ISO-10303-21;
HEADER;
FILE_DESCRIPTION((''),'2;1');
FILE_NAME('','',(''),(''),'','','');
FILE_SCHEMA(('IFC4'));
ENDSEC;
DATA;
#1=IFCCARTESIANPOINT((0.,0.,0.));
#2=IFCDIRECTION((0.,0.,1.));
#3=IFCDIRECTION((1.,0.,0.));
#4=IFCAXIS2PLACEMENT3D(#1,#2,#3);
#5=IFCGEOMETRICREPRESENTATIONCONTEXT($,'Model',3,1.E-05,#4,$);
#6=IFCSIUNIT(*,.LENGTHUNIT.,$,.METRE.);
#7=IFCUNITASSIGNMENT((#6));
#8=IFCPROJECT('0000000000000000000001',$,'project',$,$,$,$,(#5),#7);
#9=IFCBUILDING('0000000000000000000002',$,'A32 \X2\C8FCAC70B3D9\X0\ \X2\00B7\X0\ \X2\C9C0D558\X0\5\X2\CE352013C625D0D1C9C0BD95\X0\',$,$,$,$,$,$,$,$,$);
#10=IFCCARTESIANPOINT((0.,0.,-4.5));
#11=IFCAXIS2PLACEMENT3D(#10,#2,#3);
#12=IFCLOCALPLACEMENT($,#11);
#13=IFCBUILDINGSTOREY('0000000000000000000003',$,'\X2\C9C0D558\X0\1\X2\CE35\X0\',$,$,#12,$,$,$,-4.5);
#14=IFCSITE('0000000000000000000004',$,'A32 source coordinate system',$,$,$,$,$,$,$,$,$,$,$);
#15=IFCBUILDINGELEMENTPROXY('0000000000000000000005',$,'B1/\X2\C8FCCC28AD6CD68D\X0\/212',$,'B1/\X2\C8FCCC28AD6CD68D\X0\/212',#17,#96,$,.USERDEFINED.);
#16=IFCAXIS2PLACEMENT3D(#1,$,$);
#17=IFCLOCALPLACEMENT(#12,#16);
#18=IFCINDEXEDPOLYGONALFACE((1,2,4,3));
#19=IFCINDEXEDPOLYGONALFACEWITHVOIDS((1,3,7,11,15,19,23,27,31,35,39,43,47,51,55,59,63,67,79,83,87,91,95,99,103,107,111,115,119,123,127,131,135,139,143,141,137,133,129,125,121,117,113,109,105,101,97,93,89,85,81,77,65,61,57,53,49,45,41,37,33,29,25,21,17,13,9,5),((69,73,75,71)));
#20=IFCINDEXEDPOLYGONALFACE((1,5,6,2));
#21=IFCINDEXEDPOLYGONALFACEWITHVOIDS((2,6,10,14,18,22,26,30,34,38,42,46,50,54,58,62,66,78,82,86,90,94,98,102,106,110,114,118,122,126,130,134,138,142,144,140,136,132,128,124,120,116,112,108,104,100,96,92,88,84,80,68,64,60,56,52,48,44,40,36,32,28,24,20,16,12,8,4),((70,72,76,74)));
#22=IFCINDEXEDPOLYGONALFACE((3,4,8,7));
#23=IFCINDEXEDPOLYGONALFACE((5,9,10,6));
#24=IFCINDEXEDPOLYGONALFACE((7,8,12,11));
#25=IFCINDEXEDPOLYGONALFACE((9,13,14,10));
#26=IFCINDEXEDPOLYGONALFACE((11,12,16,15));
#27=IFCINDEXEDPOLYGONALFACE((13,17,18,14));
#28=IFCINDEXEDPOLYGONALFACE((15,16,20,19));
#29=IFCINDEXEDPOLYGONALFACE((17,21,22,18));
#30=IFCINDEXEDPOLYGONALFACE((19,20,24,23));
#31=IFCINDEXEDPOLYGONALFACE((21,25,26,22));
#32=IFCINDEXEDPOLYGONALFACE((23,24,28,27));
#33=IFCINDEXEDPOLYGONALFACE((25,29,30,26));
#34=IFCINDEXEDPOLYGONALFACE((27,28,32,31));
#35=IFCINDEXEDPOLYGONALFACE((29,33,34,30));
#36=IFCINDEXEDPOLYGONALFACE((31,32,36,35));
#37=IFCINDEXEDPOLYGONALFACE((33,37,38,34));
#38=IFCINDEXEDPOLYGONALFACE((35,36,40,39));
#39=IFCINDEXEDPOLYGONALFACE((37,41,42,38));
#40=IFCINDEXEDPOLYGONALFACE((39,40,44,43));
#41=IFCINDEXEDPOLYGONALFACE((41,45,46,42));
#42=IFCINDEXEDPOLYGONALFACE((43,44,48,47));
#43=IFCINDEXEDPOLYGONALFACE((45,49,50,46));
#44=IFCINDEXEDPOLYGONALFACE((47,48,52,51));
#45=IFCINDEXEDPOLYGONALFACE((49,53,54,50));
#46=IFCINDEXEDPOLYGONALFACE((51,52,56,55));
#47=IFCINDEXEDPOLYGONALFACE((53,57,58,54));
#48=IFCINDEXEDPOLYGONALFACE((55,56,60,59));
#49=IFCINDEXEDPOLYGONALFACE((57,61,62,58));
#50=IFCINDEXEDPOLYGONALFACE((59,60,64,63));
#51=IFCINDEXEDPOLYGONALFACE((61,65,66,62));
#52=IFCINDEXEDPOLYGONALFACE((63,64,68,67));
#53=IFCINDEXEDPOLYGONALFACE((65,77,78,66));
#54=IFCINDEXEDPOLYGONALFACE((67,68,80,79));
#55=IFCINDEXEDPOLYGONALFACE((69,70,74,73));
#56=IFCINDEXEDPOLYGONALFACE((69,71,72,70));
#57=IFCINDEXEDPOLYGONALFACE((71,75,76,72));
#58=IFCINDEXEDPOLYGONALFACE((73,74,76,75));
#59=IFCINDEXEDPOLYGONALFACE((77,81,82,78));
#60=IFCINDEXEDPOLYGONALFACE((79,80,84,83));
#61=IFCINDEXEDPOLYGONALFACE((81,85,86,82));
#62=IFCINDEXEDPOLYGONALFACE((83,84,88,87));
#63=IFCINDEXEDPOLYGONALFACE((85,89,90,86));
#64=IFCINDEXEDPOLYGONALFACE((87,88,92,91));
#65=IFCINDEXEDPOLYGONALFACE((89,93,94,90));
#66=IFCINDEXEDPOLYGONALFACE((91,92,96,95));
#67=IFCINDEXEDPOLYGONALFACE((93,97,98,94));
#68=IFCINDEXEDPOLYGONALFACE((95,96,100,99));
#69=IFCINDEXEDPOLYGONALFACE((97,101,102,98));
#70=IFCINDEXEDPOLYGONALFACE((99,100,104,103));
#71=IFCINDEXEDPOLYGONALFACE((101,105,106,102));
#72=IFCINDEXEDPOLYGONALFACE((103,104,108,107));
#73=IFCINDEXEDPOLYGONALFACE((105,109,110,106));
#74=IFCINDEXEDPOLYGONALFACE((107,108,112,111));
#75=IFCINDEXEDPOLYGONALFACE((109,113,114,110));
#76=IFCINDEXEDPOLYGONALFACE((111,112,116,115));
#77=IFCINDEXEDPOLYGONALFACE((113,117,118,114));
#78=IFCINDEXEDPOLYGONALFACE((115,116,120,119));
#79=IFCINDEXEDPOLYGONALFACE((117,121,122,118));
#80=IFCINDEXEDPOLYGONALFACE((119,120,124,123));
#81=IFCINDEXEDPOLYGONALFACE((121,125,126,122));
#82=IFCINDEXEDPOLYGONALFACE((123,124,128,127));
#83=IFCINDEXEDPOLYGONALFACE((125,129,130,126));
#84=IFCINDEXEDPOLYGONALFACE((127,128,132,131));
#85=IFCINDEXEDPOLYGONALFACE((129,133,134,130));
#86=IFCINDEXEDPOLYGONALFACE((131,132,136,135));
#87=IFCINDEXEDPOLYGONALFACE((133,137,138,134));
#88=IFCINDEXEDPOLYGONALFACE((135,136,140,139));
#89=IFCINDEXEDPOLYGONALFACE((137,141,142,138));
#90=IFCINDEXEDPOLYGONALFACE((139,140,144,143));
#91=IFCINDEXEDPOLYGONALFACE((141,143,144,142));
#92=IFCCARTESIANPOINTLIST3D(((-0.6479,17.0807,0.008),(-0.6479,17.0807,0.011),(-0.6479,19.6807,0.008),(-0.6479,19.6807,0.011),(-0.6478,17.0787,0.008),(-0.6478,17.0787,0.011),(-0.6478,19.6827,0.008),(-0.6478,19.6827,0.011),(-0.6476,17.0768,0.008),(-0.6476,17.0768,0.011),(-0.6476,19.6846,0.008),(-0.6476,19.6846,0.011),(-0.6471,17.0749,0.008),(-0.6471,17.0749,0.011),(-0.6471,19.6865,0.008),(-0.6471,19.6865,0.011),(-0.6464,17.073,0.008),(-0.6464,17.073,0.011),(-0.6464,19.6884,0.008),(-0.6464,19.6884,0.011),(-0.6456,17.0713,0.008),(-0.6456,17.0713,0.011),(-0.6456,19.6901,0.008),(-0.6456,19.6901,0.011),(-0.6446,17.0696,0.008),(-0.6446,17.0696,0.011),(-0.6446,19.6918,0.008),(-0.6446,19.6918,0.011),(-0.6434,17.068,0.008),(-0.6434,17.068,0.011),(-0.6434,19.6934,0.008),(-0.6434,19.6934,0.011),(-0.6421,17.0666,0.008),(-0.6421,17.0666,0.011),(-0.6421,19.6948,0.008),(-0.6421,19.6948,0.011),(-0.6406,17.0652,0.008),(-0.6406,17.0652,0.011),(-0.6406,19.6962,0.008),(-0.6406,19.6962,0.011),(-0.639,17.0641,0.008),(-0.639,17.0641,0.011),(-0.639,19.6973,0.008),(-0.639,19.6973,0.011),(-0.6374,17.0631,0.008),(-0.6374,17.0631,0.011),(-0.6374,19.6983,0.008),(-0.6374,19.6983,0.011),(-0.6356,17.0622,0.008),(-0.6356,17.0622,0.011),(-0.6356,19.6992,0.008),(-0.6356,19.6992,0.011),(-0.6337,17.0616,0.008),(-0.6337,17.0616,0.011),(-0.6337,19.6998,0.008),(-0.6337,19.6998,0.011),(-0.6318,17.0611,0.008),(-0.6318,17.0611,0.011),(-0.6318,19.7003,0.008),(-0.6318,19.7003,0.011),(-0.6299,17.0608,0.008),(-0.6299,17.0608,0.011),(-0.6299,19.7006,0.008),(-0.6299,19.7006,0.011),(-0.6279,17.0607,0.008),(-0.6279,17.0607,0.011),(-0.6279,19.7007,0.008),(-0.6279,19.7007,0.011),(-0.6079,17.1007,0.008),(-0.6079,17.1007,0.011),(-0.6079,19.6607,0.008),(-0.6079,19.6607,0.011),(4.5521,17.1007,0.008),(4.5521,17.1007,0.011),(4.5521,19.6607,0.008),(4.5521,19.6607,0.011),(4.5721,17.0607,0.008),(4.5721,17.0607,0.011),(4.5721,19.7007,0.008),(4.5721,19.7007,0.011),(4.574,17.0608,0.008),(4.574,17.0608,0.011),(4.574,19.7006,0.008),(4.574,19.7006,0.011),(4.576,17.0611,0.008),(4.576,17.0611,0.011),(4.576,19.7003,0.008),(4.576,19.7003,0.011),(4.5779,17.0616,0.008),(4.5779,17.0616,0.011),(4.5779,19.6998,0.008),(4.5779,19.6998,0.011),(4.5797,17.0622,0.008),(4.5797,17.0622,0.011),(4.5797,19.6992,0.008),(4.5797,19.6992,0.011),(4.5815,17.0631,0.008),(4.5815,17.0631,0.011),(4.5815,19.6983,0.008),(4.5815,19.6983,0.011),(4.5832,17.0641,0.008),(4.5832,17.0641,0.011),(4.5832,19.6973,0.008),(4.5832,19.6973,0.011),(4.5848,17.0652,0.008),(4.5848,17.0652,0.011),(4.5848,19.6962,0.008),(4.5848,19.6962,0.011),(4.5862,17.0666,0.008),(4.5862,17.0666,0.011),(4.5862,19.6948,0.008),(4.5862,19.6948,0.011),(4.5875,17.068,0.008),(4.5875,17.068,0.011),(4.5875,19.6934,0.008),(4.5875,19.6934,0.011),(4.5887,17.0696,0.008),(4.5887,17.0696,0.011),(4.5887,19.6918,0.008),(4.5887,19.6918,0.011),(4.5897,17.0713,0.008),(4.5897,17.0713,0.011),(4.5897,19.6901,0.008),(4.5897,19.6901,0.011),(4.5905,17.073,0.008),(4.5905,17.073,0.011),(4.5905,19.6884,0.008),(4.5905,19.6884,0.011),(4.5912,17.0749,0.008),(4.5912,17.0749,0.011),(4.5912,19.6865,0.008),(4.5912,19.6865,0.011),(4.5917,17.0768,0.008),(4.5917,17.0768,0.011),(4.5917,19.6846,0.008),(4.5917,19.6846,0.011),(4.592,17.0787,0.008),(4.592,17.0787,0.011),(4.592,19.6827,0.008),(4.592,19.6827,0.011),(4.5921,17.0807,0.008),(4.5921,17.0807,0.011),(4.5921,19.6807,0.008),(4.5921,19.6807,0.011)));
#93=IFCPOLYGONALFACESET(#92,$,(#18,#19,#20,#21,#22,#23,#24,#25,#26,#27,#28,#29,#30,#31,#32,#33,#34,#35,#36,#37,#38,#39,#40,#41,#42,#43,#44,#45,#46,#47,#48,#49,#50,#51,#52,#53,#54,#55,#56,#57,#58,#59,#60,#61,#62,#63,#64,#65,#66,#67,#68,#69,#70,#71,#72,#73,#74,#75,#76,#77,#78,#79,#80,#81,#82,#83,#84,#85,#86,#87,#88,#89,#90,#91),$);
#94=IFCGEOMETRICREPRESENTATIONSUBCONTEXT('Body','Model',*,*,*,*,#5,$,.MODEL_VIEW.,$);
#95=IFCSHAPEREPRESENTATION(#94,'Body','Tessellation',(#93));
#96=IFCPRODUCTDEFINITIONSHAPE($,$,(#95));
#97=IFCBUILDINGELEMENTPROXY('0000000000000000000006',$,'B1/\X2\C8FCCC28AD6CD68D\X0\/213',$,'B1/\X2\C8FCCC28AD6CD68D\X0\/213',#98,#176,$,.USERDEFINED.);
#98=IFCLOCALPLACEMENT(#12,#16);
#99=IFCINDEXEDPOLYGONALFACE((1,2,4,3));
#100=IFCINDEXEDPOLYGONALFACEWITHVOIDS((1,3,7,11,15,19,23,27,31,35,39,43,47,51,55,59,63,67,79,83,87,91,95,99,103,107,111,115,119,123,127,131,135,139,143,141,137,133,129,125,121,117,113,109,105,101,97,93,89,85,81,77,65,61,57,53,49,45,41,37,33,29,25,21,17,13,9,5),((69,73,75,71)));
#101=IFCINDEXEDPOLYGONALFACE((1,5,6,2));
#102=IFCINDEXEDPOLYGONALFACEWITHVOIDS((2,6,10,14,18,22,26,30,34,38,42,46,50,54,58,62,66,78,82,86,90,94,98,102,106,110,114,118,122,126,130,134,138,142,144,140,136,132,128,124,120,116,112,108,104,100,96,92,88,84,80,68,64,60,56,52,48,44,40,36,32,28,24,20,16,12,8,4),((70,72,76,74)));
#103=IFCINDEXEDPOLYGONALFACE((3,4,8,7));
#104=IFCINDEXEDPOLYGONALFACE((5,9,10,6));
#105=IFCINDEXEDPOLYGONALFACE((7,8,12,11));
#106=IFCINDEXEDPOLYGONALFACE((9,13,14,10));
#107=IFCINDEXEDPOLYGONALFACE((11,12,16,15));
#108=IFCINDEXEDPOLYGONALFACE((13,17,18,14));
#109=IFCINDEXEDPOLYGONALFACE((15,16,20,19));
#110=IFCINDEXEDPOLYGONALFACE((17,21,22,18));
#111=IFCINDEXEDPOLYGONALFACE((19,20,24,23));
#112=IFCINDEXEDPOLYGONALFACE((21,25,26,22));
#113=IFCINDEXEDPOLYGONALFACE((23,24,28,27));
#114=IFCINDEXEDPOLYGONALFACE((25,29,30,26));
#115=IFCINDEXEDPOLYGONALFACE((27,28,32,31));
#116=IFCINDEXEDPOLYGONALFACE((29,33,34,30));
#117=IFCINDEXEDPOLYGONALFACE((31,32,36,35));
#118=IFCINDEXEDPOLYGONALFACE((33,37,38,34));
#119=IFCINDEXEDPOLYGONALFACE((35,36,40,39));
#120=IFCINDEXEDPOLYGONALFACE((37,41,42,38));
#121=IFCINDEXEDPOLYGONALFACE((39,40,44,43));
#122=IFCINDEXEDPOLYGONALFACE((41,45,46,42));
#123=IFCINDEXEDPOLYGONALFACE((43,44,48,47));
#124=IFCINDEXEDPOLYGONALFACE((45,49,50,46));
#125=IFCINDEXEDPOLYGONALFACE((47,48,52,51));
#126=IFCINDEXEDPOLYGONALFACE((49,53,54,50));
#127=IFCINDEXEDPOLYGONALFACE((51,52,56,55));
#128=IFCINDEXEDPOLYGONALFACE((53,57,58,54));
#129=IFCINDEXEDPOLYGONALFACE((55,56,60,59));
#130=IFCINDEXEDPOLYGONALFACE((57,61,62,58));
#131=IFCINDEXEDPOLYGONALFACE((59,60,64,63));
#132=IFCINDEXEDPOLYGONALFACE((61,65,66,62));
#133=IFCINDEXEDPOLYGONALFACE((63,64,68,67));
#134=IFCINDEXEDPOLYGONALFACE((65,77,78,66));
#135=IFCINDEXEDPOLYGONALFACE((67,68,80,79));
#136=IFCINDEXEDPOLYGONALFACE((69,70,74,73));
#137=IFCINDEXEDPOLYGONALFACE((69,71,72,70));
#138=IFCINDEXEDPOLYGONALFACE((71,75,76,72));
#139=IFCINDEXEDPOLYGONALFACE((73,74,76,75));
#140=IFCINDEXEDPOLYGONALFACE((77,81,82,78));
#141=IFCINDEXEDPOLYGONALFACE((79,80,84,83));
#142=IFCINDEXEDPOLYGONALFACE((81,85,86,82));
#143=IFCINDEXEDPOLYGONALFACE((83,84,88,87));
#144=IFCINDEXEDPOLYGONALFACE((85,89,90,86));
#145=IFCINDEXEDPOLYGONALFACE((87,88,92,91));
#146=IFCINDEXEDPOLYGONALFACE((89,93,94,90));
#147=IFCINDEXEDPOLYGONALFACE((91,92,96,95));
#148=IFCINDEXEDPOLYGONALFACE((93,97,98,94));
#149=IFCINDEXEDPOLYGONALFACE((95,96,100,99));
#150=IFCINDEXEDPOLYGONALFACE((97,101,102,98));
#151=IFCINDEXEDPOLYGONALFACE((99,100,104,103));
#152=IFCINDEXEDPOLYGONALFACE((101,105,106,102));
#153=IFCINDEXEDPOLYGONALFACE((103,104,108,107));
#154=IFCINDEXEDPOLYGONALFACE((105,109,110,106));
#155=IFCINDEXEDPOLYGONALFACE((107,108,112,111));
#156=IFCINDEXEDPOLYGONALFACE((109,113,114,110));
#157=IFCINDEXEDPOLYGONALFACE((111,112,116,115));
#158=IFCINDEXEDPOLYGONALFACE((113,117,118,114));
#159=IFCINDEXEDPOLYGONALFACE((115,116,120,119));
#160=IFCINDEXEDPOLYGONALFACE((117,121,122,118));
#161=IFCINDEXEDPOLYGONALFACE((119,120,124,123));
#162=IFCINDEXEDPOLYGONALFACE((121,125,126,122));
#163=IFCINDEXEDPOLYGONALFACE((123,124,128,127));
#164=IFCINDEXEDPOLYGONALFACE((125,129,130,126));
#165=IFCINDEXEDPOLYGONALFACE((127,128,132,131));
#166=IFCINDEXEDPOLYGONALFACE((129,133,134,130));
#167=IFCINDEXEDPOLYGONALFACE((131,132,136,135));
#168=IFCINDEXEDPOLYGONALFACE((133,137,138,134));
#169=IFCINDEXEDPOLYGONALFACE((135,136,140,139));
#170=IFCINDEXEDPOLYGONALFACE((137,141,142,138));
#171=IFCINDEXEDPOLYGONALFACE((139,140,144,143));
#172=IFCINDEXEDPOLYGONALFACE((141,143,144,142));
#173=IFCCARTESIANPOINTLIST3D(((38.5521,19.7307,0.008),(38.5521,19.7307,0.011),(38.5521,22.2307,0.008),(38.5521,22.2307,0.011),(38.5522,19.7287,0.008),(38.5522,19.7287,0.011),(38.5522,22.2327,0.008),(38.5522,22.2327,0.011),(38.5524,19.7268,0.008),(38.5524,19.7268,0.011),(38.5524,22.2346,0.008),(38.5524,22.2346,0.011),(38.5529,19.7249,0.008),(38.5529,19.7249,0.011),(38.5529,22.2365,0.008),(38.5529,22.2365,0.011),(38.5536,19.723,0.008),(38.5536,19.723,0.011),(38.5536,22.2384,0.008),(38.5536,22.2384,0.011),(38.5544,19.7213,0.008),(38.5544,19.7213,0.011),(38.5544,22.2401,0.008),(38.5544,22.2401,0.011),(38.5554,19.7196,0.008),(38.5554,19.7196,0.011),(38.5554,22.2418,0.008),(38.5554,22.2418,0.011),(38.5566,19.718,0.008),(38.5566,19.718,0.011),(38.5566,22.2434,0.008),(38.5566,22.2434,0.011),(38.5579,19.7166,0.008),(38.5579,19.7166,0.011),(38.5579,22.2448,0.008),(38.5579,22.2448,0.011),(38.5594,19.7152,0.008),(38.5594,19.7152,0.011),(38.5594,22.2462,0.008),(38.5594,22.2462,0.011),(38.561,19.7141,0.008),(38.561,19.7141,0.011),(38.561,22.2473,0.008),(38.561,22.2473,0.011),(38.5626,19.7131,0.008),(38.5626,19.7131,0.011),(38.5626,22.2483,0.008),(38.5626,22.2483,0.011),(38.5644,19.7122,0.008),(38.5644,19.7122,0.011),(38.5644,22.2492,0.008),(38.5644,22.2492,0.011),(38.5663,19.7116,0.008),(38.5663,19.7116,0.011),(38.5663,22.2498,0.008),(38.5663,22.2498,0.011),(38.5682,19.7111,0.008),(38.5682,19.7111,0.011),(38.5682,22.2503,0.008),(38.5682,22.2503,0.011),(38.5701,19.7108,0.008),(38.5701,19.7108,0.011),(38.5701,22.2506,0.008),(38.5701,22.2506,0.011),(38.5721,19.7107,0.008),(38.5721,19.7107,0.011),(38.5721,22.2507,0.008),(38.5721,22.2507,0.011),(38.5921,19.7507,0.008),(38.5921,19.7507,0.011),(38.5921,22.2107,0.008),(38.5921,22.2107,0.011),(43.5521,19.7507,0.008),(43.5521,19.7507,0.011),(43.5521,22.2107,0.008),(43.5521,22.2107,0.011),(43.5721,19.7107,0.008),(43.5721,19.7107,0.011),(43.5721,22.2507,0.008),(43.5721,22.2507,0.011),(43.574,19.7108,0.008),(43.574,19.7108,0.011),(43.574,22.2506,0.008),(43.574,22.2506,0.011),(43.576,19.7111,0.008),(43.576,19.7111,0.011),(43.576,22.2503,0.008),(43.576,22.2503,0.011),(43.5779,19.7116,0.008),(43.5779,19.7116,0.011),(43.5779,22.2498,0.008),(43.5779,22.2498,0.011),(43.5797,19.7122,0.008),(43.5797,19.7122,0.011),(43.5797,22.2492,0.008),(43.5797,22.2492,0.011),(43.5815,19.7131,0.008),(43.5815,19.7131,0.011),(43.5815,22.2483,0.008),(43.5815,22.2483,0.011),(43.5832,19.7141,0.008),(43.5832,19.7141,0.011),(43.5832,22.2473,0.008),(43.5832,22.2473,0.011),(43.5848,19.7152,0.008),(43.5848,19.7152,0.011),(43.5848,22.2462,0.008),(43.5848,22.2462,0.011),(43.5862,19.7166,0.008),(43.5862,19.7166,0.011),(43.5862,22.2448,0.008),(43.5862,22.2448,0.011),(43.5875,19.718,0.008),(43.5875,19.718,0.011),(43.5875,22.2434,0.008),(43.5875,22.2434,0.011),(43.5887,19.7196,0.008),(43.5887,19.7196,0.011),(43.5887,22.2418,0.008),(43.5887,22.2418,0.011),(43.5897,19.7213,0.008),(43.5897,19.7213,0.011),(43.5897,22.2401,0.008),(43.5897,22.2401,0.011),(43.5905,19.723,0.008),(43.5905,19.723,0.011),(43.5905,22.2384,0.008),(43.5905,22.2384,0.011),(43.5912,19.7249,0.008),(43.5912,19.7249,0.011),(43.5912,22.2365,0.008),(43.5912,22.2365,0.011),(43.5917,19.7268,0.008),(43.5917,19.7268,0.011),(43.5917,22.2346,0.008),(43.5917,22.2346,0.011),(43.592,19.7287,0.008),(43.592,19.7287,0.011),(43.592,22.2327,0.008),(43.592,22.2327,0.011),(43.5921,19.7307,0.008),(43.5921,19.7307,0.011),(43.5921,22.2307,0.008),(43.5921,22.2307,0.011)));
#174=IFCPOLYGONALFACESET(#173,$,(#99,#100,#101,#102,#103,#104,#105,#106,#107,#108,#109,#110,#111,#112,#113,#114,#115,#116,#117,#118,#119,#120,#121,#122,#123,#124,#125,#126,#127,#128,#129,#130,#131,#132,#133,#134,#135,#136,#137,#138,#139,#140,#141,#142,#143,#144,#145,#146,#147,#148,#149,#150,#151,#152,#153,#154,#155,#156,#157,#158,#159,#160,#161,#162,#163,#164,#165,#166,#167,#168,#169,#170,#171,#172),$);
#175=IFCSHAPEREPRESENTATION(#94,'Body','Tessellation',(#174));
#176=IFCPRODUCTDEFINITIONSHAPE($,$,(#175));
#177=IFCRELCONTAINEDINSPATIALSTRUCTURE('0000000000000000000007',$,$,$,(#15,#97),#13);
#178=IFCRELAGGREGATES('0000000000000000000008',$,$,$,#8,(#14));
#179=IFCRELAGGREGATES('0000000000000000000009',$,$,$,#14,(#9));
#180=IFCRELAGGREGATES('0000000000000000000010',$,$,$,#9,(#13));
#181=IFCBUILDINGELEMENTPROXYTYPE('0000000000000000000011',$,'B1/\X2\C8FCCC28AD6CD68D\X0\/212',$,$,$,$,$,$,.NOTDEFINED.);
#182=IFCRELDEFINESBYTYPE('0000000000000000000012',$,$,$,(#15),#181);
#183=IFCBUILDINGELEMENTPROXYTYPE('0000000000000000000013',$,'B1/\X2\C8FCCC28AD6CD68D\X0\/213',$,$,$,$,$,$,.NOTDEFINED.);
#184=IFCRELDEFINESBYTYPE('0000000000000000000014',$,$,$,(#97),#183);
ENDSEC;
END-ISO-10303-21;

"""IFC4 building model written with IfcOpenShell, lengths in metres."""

from ifc_helpers import new_model, si_unit, frame, origin, origin_with_axes, place, context, subcontext, project, spatial, polyline, outline, extrude, source, transform, mapped, type_object, type_shapes, element, save


model = new_model("IFC4")

# Units and contexts
model_context = context("Model", 3, precision=1e-05, world=origin_with_axes())
body_context = subcontext(model_context, "Body", "Model", "MODEL_VIEW")
ifc_project = project(units=[si_unit("LENGTHUNIT", "METRE")], contexts=[model_context])

# Site, building, storey
site = spatial("IfcSite", under=ifc_project, Name="A32 source coordinate system")
building = spatial("IfcBuilding", under=site, Name="A32 주거동 · 지하5층–옥탑지붕")
storey_placement = place(None, frame((0.0, 0.0, -4.5), z_axis=(0.0, 0.0, 1.0), x_axis=(1.0, 0.0, 0.0)))
storey = spatial("IfcBuildingStorey", under=building, at=storey_placement, Name="지하1층", Elevation=-4.5)

# Building element proxies
building_element_proxy_type_1 = type_object("IfcBuildingElementProxyType", Name="B1/주차구획/212", PredefinedType="NOTDEFINED")
shared_shape_1 = source(origin(), body_context, "Body", "SweptSolid", [
    extrude(outline(polyline([(-0.6279, 17.0607), (-0.6299, 17.0608), (-0.6318, 17.0611), (-0.6337, 17.0616), (-0.6356, 17.0622), (-0.6374, 17.0631), (-0.639, 17.0641), (-0.6406, 17.0652), (-0.6421, 17.0666), (-0.6434, 17.068), (-0.6446, 17.0696), (-0.6456, 17.0713), (-0.6464, 17.073), (-0.6471, 17.0749), (-0.6476, 17.0768), (-0.6478, 17.0787), (-0.6479, 17.0807), (-0.6479, 19.6807), (-0.6478, 19.6827), (-0.6476, 19.6846), (-0.6471, 19.6865), (-0.6464, 19.6884), (-0.6456, 19.6901), (-0.6446, 19.6918), (-0.6434, 19.6934), (-0.6421, 19.6948), (-0.6406, 19.6962), (-0.639, 19.6973), (-0.6374, 19.6983), (-0.6356, 19.6992), (-0.6337, 19.6998), (-0.6318, 19.7003), (-0.6299, 19.7006), (-0.6279, 19.7007), (4.5721, 19.7007), (4.574, 19.7006), (4.576, 19.7003), (4.5779, 19.6998), (4.5797, 19.6992), (4.5815, 19.6983), (4.5832, 19.6973), (4.5848, 19.6962), (4.5862, 19.6948), (4.5875, 19.6934), (4.5887, 19.6918), (4.5897, 19.6901), (4.5905, 19.6884), (4.5912, 19.6865), (4.5917, 19.6846), (4.592, 19.6827), (4.5921, 19.6807), (4.5921, 17.0807), (4.592, 17.0787), (4.5917, 17.0768), (4.5912, 17.0749), (4.5905, 17.073), (4.5897, 17.0713), (4.5887, 17.0696), (4.5875, 17.068), (4.5862, 17.0666), (4.5848, 17.0652), (4.5832, 17.0641), (4.5815, 17.0631), (4.5797, 17.0622), (4.5779, 17.0616), (4.576, 17.0611), (4.574, 17.0608), (4.5721, 17.0607), (-0.6279, 17.0607)]), holes=[polyline([(-0.6079, 17.1007), (4.5521, 17.1007), (4.5521, 19.6607), (-0.6079, 19.6607), (-0.6079, 17.1007)])]), frame((0.0, 0.0, 0.008)), (0.0, 0.0, 1.0), 0.003),
])
type_shapes(building_element_proxy_type_1, [shared_shape_1])
proxy_1_placement = place(storey_placement, origin_with_axes())
element("IfcBuildingElementProxy", 1, at=proxy_1_placement, inside=storey, type_object=building_element_proxy_type_1, Name="B1/주차구획/212", ObjectType="B1/주차구획/212", PredefinedType="USERDEFINED", context=body_context, shape_type="MappedRepresentation", body=[
    mapped(shared_shape_1, transform((0.0, 0.0, 0.0), scale=1.0)),
])
building_element_proxy_type_2 = type_object("IfcBuildingElementProxyType", Name="B1/주차구획/213", PredefinedType="NOTDEFINED")
shared_shape_2 = source(origin(), body_context, "Body", "SweptSolid", [
    extrude(outline(polyline([(43.5721, 22.2507), (43.574, 22.2506), (43.576, 22.2503), (43.5779, 22.2498), (43.5797, 22.2492), (43.5815, 22.2483), (43.5832, 22.2473), (43.5848, 22.2462), (43.5862, 22.2448), (43.5875, 22.2434), (43.5887, 22.2418), (43.5897, 22.2401), (43.5905, 22.2384), (43.5912, 22.2365), (43.5917, 22.2346), (43.592, 22.2327), (43.5921, 22.2307), (43.5921, 19.7307), (43.592, 19.7287), (43.5917, 19.7268), (43.5912, 19.7249), (43.5905, 19.723), (43.5897, 19.7213), (43.5887, 19.7196), (43.5875, 19.718), (43.5862, 19.7166), (43.5848, 19.7152), (43.5832, 19.7141), (43.5815, 19.7131), (43.5797, 19.7122), (43.5779, 19.7116), (43.576, 19.7111), (43.574, 19.7108), (43.5721, 19.7107), (38.5721, 19.7107), (38.5701, 19.7108), (38.5682, 19.7111), (38.5663, 19.7116), (38.5644, 19.7122), (38.5626, 19.7131), (38.561, 19.7141), (38.5594, 19.7152), (38.5579, 19.7166), (38.5566, 19.718), (38.5554, 19.7196), (38.5544, 19.7213), (38.5536, 19.723), (38.5529, 19.7249), (38.5524, 19.7268), (38.5522, 19.7287), (38.5521, 19.7307), (38.5521, 22.2307), (38.5522, 22.2327), (38.5524, 22.2346), (38.5529, 22.2365), (38.5536, 22.2384), (38.5544, 22.2401), (38.5554, 22.2418), (38.5566, 22.2434), (38.5579, 22.2448), (38.5594, 22.2462), (38.561, 22.2473), (38.5626, 22.2483), (38.5644, 22.2492), (38.5663, 22.2498), (38.5682, 22.2503), (38.5701, 22.2506), (38.5721, 22.2507), (43.5721, 22.2507)]), holes=[polyline([(43.5521, 22.2107), (38.5921, 22.2107), (38.5921, 19.7507), (43.5521, 19.7507), (43.5521, 22.2107)])]), frame((0.0, 0.0, 0.008)), (0.0, 0.0, 1.0), 0.003),
])
type_shapes(building_element_proxy_type_2, [shared_shape_2])
proxy_2_placement = place(storey_placement, origin_with_axes())
element("IfcBuildingElementProxy", 2, at=proxy_2_placement, inside=storey, type_object=building_element_proxy_type_2, Name="B1/주차구획/213", ObjectType="B1/주차구획/213", PredefinedType="USERDEFINED", context=body_context, shape_type="MappedRepresentation", body=[
    mapped(shared_shape_2, transform((0.0, 0.0, 0.0), scale=1.0)),
])

save(model, "model.ifc")
